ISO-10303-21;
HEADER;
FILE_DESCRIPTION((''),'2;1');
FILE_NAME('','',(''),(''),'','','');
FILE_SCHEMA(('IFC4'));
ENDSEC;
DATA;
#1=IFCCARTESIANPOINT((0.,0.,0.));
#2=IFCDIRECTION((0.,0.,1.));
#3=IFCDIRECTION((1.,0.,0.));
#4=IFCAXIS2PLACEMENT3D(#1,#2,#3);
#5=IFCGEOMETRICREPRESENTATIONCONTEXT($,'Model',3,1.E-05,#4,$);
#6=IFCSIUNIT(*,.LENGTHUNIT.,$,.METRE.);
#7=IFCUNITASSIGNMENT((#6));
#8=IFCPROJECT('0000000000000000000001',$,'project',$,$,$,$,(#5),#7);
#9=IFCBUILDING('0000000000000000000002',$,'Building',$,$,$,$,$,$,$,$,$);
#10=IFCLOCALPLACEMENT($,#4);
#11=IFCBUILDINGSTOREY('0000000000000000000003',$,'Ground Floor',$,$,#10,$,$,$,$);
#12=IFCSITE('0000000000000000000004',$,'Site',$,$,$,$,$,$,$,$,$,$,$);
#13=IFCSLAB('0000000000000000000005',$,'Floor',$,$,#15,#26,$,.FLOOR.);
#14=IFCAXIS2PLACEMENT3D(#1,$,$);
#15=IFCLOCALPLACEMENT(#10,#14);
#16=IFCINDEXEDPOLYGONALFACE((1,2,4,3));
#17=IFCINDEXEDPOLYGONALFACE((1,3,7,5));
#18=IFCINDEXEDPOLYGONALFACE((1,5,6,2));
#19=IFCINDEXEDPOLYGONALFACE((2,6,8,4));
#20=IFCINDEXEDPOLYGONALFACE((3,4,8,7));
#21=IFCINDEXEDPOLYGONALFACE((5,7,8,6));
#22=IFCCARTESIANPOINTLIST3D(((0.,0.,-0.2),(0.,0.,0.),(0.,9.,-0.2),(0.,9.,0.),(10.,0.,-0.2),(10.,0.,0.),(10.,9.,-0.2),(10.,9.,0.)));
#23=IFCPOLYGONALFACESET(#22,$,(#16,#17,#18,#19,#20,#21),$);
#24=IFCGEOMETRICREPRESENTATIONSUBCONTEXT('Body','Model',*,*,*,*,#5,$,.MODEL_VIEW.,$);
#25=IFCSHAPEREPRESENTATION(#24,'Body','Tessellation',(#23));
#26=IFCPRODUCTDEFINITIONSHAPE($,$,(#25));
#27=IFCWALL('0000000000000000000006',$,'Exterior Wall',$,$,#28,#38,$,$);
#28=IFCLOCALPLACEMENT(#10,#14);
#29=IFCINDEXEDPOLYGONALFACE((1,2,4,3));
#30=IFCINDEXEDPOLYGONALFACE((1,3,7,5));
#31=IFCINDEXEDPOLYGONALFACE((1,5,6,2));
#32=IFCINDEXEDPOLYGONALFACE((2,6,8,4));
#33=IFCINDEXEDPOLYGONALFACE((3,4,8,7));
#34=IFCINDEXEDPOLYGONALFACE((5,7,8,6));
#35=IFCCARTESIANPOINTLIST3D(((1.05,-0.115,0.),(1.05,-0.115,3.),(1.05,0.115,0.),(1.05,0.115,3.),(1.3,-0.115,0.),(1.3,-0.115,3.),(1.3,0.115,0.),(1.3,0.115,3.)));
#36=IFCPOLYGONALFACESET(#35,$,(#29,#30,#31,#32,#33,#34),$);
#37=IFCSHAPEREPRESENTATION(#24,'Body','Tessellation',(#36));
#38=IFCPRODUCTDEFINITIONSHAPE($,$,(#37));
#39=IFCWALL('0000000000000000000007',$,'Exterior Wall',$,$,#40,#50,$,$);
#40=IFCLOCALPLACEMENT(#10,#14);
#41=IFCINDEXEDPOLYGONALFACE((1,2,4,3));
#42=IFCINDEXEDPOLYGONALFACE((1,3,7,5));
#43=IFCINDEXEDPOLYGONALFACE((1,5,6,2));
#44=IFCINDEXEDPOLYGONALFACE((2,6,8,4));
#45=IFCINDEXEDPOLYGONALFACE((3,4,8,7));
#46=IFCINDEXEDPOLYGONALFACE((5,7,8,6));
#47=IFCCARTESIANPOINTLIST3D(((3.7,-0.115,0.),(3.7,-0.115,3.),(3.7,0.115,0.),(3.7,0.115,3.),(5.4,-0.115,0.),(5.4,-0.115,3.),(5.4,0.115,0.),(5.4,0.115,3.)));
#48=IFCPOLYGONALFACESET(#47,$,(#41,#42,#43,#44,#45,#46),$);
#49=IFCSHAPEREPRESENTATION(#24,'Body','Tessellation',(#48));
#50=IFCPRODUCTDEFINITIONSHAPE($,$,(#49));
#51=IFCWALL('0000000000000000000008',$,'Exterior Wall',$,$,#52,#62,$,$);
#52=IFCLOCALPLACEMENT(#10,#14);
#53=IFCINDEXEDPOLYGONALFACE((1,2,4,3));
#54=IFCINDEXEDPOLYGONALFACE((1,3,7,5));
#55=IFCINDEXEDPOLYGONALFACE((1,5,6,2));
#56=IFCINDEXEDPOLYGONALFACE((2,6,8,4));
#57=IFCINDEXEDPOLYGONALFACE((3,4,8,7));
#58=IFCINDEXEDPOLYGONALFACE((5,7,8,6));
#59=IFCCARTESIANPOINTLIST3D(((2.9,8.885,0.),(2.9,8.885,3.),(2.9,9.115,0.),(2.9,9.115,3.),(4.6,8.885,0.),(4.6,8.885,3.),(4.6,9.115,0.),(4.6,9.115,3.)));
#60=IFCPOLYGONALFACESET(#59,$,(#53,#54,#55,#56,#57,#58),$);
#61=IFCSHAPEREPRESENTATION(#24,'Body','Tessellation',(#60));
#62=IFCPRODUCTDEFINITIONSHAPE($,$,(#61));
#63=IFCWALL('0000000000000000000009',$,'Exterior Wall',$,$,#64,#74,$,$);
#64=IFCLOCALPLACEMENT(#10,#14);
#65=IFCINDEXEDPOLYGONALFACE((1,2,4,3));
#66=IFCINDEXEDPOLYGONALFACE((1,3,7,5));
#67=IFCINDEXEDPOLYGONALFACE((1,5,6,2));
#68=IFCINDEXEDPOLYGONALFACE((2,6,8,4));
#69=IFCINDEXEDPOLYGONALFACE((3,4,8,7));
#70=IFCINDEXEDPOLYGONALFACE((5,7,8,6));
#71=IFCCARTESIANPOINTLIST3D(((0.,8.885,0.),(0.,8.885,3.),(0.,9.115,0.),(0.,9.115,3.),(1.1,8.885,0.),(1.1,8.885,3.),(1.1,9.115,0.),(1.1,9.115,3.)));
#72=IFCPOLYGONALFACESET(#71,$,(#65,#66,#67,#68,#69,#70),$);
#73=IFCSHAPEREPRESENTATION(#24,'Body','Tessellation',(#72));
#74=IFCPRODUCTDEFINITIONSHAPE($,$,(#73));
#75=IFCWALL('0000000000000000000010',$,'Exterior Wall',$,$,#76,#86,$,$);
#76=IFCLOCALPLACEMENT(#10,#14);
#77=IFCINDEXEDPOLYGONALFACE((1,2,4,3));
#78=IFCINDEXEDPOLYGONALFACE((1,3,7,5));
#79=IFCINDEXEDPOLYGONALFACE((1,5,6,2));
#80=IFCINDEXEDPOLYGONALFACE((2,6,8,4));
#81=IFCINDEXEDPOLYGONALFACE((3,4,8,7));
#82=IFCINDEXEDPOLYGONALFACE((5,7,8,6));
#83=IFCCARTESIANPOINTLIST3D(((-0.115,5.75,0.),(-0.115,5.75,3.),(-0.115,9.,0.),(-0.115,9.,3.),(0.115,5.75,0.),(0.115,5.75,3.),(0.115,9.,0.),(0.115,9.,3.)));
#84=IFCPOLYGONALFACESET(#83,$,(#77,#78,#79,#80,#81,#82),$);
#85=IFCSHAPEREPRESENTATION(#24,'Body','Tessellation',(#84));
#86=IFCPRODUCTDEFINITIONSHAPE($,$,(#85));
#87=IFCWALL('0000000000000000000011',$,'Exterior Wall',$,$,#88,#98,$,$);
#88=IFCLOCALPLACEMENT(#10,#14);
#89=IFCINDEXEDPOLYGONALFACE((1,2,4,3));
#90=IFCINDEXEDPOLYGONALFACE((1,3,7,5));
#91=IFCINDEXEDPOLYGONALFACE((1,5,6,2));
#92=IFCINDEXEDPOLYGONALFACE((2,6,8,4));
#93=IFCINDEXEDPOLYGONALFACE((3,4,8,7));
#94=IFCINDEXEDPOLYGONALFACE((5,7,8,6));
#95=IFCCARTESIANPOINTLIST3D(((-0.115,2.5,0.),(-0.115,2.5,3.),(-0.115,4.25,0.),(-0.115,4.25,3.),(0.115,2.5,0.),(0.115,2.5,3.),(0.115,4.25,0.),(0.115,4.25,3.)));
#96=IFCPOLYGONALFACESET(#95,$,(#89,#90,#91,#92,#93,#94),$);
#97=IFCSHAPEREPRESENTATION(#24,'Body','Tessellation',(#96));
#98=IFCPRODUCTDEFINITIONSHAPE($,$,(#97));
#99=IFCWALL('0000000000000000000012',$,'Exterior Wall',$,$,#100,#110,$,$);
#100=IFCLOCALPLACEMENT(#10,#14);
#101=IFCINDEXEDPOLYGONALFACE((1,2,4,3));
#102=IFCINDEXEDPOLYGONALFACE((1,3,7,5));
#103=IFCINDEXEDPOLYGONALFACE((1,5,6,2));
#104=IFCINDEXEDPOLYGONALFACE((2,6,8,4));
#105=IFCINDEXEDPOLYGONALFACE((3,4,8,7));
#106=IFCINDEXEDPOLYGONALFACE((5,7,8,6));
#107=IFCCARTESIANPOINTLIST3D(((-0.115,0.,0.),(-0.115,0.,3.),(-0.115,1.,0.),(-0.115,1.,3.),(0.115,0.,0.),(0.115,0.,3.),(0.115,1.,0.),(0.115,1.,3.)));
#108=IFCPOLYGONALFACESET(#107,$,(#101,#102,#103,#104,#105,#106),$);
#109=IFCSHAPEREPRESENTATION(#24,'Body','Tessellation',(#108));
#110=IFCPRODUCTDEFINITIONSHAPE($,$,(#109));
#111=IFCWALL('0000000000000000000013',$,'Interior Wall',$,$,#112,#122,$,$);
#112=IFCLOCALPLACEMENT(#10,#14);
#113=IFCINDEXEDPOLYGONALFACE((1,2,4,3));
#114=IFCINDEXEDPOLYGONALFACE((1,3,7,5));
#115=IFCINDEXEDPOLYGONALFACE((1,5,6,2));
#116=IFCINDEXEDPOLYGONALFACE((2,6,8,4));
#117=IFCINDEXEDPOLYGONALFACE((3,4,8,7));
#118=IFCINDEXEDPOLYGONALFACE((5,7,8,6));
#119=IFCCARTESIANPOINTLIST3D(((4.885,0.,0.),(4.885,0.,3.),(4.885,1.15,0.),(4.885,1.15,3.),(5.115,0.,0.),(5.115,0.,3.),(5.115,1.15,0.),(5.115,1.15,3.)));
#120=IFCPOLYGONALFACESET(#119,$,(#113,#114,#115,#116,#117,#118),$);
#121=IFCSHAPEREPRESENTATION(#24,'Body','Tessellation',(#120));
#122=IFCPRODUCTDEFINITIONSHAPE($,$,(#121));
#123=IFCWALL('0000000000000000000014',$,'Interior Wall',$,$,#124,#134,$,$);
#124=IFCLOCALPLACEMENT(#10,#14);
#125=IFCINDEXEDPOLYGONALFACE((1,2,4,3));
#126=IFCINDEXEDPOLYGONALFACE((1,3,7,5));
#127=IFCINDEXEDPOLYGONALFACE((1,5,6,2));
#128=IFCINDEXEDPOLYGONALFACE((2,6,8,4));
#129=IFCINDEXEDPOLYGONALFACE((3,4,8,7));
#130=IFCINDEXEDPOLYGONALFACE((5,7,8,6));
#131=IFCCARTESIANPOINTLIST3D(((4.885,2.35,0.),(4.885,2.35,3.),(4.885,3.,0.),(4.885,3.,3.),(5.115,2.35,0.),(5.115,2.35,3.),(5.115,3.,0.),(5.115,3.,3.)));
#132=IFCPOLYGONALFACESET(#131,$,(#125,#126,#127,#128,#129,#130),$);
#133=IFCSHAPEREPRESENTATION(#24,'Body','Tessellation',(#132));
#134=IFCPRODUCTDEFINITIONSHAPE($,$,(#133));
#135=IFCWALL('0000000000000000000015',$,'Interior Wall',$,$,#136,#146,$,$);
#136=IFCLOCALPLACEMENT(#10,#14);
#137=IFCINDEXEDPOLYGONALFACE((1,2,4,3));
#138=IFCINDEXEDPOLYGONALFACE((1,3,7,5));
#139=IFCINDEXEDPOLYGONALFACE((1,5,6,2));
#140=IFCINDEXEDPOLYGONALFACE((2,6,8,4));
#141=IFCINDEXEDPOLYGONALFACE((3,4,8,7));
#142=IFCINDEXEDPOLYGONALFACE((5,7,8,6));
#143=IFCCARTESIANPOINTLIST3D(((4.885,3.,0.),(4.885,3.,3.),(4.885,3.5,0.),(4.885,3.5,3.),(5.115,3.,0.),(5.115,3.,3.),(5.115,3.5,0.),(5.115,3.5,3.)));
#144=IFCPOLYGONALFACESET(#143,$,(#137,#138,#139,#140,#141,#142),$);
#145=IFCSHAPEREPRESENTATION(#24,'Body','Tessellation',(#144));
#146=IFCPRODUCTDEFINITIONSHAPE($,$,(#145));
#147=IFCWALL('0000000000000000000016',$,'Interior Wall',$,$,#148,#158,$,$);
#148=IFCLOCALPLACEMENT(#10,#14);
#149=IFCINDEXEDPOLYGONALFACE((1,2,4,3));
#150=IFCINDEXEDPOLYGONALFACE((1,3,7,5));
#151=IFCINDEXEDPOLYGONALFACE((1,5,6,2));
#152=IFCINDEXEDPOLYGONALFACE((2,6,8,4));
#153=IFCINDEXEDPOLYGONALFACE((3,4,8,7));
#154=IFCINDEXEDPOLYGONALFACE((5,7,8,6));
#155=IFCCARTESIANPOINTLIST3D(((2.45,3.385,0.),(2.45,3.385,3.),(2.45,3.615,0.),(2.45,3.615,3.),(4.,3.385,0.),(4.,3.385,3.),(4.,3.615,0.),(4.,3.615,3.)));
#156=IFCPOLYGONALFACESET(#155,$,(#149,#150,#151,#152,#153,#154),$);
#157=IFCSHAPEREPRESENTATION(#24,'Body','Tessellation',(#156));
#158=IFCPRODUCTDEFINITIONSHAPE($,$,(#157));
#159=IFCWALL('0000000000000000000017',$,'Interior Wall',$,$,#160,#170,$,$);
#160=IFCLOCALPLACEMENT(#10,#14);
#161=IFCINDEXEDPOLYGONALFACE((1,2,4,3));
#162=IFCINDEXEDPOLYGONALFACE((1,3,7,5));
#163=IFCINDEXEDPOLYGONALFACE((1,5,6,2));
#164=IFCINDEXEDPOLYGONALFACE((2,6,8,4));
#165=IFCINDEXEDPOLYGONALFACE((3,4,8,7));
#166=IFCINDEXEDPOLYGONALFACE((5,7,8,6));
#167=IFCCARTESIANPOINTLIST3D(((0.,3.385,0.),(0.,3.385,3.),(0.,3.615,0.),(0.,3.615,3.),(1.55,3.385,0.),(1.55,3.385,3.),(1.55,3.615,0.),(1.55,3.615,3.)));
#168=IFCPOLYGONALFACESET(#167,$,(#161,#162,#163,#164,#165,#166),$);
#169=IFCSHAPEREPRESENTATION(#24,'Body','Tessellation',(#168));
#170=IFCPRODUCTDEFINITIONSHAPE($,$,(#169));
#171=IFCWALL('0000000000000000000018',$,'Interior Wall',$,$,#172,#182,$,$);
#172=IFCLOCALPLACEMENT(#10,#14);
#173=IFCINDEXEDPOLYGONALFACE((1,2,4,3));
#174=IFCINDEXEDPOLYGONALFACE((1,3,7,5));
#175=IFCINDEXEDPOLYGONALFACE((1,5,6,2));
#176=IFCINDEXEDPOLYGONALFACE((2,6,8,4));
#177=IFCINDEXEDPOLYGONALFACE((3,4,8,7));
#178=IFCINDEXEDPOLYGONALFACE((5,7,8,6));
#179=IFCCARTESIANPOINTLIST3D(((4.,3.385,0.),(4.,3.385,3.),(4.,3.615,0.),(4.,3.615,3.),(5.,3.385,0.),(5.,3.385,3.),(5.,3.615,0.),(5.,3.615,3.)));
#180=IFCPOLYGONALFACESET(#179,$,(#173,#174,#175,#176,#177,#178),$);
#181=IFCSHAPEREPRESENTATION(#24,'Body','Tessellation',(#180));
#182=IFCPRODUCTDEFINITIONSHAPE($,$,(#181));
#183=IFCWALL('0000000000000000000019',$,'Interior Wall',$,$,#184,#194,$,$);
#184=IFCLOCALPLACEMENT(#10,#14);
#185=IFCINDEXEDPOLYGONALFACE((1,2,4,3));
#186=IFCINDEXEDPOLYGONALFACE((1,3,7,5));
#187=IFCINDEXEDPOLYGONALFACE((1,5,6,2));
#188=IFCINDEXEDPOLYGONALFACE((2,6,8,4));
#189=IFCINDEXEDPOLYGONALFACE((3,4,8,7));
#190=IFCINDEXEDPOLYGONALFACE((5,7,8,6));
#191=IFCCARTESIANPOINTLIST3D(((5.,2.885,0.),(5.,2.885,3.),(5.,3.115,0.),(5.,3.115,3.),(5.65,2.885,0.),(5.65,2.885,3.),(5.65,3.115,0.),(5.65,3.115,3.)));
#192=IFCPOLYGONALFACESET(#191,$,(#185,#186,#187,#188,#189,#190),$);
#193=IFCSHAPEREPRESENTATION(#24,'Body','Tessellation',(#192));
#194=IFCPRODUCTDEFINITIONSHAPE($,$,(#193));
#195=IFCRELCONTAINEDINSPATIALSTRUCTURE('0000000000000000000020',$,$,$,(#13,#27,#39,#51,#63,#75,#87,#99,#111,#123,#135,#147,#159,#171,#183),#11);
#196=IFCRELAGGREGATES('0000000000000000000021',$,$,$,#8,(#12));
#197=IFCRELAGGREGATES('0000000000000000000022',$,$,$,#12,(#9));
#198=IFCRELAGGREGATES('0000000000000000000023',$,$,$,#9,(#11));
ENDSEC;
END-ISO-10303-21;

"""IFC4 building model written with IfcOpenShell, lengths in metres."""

from ifc_helpers import new_model, si_unit, frame, origin_with_axes, place, context, subcontext, project, spatial, indexed_curve, outline, extrude, element, save


model = new_model("IFC4")

# Units and contexts
model_context = context("Model", 3, precision=1e-05, world=origin_with_axes())
body_context = subcontext(model_context, "Body", "Model", "MODEL_VIEW")
ifc_project = project(units=[si_unit("LENGTHUNIT", "METRE")], contexts=[model_context])

# Site, building, storey
site = spatial("IfcSite", under=ifc_project, Name="Site")
building = spatial("IfcBuilding", under=site, Name="Building")
storey_placement = place(None, origin_with_axes())
storey = spatial("IfcBuildingStorey", under=building, at=storey_placement, Name="Ground Floor")

# Slab
slab_placement = place(storey_placement, frame((0.0, 0.0, -0.2), z_axis=(0.0, 0.0, 1.0), x_axis=(1.0, 0.0, 0.0)))
element("IfcSlab", 1, at=slab_placement, inside=storey, Name="Floor", PredefinedType="FLOOR", context=body_context, shape_type="SweptSolid", body=[
    extrude(outline(indexed_curve([(0.0, 0.0), (10.0, 0.0), (10.0, 9.0), (0.0, 9.0)])), None, (0.0, 0.0, 1.0), 0.2),
])

# Walls
wall_1_placement = place(storey_placement, frame((1.05, 0.0, 0.0), z_axis=(0.0, 0.0, 1.0), x_axis=(1.0, 0.0, 0.0)))
element("IfcWall", 2, at=wall_1_placement, inside=storey, Name="Exterior Wall", context=body_context, shape_type="SweptSolid", body=[
    extrude(outline(indexed_curve([(0.0, 0.0), (0.0, 0.23), (0.25, 0.23), (0.25, 0.0), (0.0, 0.0)], self_intersect=False)), frame((0.0, -0.115, 0.0), z_axis=(0.0, 0.0, 1.0), x_axis=(1.0, 0.0, 0.0)), (0.0, 0.0, 1.0), 3.0),
])
wall_2_placement = place(storey_placement, frame((3.7, 0.0, 0.0), z_axis=(0.0, 0.0, 1.0), x_axis=(1.0, 0.0, 0.0)))
element("IfcWall", 3, at=wall_2_placement, inside=storey, Name="Exterior Wall", context=body_context, shape_type="SweptSolid", body=[
    extrude(outline(indexed_curve([(0.0, 0.0), (0.0, 0.23), (1.7, 0.23), (1.7, 0.0), (0.0, 0.0)], self_intersect=False)), frame((0.0, -0.115, 0.0), z_axis=(0.0, 0.0, 1.0), x_axis=(1.0, 0.0, 0.0)), (0.0, 0.0, 1.0), 3.0),
])
wall_3_placement = place(storey_placement, frame((4.6, 9.0, 0.0), z_axis=(0.0, 0.0, 1.0), x_axis=(-1.0, 0.0, 0.0)))
element("IfcWall", 4, at=wall_3_placement, inside=storey, Name="Exterior Wall", context=body_context, shape_type="SweptSolid", body=[
    extrude(outline(indexed_curve([(0.0, 0.0), (0.0, 0.23), (1.7, 0.23), (1.7, 0.0), (0.0, 0.0)], self_intersect=False)), frame((0.0, -0.115, 0.0), z_axis=(0.0, 0.0, 1.0), x_axis=(1.0, 0.0, 0.0)), (0.0, 0.0, 1.0), 3.0),
])
wall_4_placement = place(storey_placement, frame((1.1, 9.0, 0.0), z_axis=(0.0, 0.0, 1.0), x_axis=(-1.0, 0.0, 0.0)))
element("IfcWall", 5, at=wall_4_placement, inside=storey, Name="Exterior Wall", context=body_context, shape_type="SweptSolid", body=[
    extrude(outline(indexed_curve([(0.0, 0.0), (0.0, 0.23), (1.1, 0.23), (1.1, 0.0), (0.0, 0.0)], self_intersect=False)), frame((0.0, -0.115, 0.0), z_axis=(0.0, 0.0, 1.0), x_axis=(1.0, 0.0, 0.0)), (0.0, 0.0, 1.0), 3.0),
])
wall_5_placement = place(storey_placement, frame((0.0, 9.0, 0.0), z_axis=(0.0, 0.0, 1.0), x_axis=(0.0, -1.0, 0.0)))
element("IfcWall", 6, at=wall_5_placement, inside=storey, Name="Exterior Wall", context=body_context, shape_type="SweptSolid", body=[
    extrude(outline(indexed_curve([(0.0, 0.0), (0.0, 0.23), (3.25, 0.23), (3.25, 0.0), (0.0, 0.0)], self_intersect=False)), frame((0.0, -0.115, 0.0), z_axis=(0.0, 0.0, 1.0), x_axis=(1.0, 0.0, 0.0)), (0.0, 0.0, 1.0), 3.0),
])
wall_6_placement = place(storey_placement, frame((0.0, 4.25, 0.0), z_axis=(0.0, 0.0, 1.0), x_axis=(0.0, -1.0, 0.0)))
element("IfcWall", 7, at=wall_6_placement, inside=storey, Name="Exterior Wall", context=body_context, shape_type="SweptSolid", body=[
    extrude(outline(indexed_curve([(0.0, 0.0), (0.0, 0.23), (1.75, 0.23), (1.75, 0.0), (0.0, 0.0)], self_intersect=False)), frame((0.0, -0.115, 0.0), z_axis=(0.0, 0.0, 1.0), x_axis=(1.0, 0.0, 0.0)), (0.0, 0.0, 1.0), 3.0),
])
wall_7_placement = place(storey_placement, frame((0.0, 1.0, 0.0), z_axis=(0.0, 0.0, 1.0), x_axis=(0.0, -1.0, 0.0)))
element("IfcWall", 8, at=wall_7_placement, inside=storey, Name="Exterior Wall", context=body_context, shape_type="SweptSolid", body=[
    extrude(outline(indexed_curve([(0.0, 0.0), (0.0, 0.23), (1.0, 0.23), (1.0, 0.0), (0.0, 0.0)], self_intersect=False)), frame((0.0, -0.115, 0.0), z_axis=(0.0, 0.0, 1.0), x_axis=(1.0, 0.0, 0.0)), (0.0, 0.0, 1.0), 3.0),
])
wall_8_placement = place(storey_placement, frame((5.0, 0.0, 0.0), z_axis=(0.0, 0.0, 1.0), x_axis=(0.0, 1.0, 0.0)))
element("IfcWall", 9, at=wall_8_placement, inside=storey, Name="Interior Wall", context=body_context, shape_type="SweptSolid", body=[
    extrude(outline(indexed_curve([(0.0, 0.0), (0.0, 0.23), (1.15, 0.23), (1.15, 0.0), (0.0, 0.0)], self_intersect=False)), frame((0.0, -0.115, 0.0), z_axis=(0.0, 0.0, 1.0), x_axis=(1.0, 0.0, 0.0)), (0.0, 0.0, 1.0), 3.0),
])
wall_9_placement = place(storey_placement, frame((5.0, 2.35, 0.0), z_axis=(0.0, 0.0, 1.0), x_axis=(0.0, 1.0, 0.0)))
element("IfcWall", 10, at=wall_9_placement, inside=storey, Name="Interior Wall", context=body_context, shape_type="SweptSolid", body=[
    extrude(outline(indexed_curve([(0.0, 0.0), (0.0, 0.23), (0.65, 0.23), (0.65, 0.0), (0.0, 0.0)], self_intersect=False)), frame((0.0, -0.115, 0.0), z_axis=(0.0, 0.0, 1.0), x_axis=(1.0, 0.0, 0.0)), (0.0, 0.0, 1.0), 3.0),
])
wall_10_placement = place(storey_placement, frame((5.0, 3.0, 0.0), z_axis=(0.0, 0.0, 1.0), x_axis=(0.0, 1.0, 0.0)))
element("IfcWall", 11, at=wall_10_placement, inside=storey, Name="Interior Wall", context=body_context, shape_type="SweptSolid", body=[
    extrude(outline(indexed_curve([(0.0, 0.0), (0.0, 0.23), (0.5, 0.23), (0.5, 0.0), (0.0, 0.0)], self_intersect=False)), frame((0.0, -0.115, 0.0), z_axis=(0.0, 0.0, 1.0), x_axis=(1.0, 0.0, 0.0)), (0.0, 0.0, 1.0), 3.0),
])
for number, where, z_axis, x_axis, name in (
    (12, (4.0, 3.5, 0.0), (0.0, 0.0, 1.0), (-1.0, 0.0, 0.0), "Interior Wall"),
    (13, (1.55, 3.5, 0.0), (0.0, 0.0, 1.0), (-1.0, 0.0, 0.0), "Interior Wall"),
):
    element("IfcWall", number, at=place(storey_placement, frame(where, z_axis=z_axis, x_axis=x_axis)), inside=storey, Name=name, context=body_context, shape_type="SweptSolid", body=[
        extrude(outline(indexed_curve([(0.0, 0.0), (0.0, 0.23), (1.55, 0.23), (1.55, 0.0), (0.0, 0.0)], self_intersect=False)), frame((0.0, -0.115, 0.0), z_axis=(0.0, 0.0, 1.0), x_axis=(1.0, 0.0, 0.0)), (0.0, 0.0, 1.0), 3.0),
    ])
wall_11_placement = place(storey_placement, frame((5.0, 3.5, 0.0), z_axis=(0.0, 0.0, 1.0), x_axis=(-1.0, 0.0, 0.0)))
element("IfcWall", 14, at=wall_11_placement, inside=storey, Name="Interior Wall", context=body_context, shape_type="SweptSolid", body=[
    extrude(outline(indexed_curve([(0.0, 0.0), (0.0, 0.23), (1.0, 0.23), (1.0, 0.0), (0.0, 0.0)], self_intersect=False)), frame((0.0, -0.115, 0.0), z_axis=(0.0, 0.0, 1.0), x_axis=(1.0, 0.0, 0.0)), (0.0, 0.0, 1.0), 3.0),
])
wall_12_placement = place(storey_placement, frame((5.65, 3.0, 0.0), z_axis=(0.0, 0.0, 1.0), x_axis=(-1.0, 0.0, 0.0)))
element("IfcWall", 15, at=wall_12_placement, inside=storey, Name="Interior Wall", context=body_context, shape_type="SweptSolid", body=[
    extrude(outline(indexed_curve([(0.0, 0.0), (0.0, 0.23), (0.65, 0.23), (0.65, 0.0), (0.0, 0.0)], self_intersect=False)), frame((0.0, -0.115, 0.0), z_axis=(0.0, 0.0, 1.0), x_axis=(1.0, 0.0, 0.0)), (0.0, 0.0, 1.0), 3.0),
])

save(model, "model.ifc")
